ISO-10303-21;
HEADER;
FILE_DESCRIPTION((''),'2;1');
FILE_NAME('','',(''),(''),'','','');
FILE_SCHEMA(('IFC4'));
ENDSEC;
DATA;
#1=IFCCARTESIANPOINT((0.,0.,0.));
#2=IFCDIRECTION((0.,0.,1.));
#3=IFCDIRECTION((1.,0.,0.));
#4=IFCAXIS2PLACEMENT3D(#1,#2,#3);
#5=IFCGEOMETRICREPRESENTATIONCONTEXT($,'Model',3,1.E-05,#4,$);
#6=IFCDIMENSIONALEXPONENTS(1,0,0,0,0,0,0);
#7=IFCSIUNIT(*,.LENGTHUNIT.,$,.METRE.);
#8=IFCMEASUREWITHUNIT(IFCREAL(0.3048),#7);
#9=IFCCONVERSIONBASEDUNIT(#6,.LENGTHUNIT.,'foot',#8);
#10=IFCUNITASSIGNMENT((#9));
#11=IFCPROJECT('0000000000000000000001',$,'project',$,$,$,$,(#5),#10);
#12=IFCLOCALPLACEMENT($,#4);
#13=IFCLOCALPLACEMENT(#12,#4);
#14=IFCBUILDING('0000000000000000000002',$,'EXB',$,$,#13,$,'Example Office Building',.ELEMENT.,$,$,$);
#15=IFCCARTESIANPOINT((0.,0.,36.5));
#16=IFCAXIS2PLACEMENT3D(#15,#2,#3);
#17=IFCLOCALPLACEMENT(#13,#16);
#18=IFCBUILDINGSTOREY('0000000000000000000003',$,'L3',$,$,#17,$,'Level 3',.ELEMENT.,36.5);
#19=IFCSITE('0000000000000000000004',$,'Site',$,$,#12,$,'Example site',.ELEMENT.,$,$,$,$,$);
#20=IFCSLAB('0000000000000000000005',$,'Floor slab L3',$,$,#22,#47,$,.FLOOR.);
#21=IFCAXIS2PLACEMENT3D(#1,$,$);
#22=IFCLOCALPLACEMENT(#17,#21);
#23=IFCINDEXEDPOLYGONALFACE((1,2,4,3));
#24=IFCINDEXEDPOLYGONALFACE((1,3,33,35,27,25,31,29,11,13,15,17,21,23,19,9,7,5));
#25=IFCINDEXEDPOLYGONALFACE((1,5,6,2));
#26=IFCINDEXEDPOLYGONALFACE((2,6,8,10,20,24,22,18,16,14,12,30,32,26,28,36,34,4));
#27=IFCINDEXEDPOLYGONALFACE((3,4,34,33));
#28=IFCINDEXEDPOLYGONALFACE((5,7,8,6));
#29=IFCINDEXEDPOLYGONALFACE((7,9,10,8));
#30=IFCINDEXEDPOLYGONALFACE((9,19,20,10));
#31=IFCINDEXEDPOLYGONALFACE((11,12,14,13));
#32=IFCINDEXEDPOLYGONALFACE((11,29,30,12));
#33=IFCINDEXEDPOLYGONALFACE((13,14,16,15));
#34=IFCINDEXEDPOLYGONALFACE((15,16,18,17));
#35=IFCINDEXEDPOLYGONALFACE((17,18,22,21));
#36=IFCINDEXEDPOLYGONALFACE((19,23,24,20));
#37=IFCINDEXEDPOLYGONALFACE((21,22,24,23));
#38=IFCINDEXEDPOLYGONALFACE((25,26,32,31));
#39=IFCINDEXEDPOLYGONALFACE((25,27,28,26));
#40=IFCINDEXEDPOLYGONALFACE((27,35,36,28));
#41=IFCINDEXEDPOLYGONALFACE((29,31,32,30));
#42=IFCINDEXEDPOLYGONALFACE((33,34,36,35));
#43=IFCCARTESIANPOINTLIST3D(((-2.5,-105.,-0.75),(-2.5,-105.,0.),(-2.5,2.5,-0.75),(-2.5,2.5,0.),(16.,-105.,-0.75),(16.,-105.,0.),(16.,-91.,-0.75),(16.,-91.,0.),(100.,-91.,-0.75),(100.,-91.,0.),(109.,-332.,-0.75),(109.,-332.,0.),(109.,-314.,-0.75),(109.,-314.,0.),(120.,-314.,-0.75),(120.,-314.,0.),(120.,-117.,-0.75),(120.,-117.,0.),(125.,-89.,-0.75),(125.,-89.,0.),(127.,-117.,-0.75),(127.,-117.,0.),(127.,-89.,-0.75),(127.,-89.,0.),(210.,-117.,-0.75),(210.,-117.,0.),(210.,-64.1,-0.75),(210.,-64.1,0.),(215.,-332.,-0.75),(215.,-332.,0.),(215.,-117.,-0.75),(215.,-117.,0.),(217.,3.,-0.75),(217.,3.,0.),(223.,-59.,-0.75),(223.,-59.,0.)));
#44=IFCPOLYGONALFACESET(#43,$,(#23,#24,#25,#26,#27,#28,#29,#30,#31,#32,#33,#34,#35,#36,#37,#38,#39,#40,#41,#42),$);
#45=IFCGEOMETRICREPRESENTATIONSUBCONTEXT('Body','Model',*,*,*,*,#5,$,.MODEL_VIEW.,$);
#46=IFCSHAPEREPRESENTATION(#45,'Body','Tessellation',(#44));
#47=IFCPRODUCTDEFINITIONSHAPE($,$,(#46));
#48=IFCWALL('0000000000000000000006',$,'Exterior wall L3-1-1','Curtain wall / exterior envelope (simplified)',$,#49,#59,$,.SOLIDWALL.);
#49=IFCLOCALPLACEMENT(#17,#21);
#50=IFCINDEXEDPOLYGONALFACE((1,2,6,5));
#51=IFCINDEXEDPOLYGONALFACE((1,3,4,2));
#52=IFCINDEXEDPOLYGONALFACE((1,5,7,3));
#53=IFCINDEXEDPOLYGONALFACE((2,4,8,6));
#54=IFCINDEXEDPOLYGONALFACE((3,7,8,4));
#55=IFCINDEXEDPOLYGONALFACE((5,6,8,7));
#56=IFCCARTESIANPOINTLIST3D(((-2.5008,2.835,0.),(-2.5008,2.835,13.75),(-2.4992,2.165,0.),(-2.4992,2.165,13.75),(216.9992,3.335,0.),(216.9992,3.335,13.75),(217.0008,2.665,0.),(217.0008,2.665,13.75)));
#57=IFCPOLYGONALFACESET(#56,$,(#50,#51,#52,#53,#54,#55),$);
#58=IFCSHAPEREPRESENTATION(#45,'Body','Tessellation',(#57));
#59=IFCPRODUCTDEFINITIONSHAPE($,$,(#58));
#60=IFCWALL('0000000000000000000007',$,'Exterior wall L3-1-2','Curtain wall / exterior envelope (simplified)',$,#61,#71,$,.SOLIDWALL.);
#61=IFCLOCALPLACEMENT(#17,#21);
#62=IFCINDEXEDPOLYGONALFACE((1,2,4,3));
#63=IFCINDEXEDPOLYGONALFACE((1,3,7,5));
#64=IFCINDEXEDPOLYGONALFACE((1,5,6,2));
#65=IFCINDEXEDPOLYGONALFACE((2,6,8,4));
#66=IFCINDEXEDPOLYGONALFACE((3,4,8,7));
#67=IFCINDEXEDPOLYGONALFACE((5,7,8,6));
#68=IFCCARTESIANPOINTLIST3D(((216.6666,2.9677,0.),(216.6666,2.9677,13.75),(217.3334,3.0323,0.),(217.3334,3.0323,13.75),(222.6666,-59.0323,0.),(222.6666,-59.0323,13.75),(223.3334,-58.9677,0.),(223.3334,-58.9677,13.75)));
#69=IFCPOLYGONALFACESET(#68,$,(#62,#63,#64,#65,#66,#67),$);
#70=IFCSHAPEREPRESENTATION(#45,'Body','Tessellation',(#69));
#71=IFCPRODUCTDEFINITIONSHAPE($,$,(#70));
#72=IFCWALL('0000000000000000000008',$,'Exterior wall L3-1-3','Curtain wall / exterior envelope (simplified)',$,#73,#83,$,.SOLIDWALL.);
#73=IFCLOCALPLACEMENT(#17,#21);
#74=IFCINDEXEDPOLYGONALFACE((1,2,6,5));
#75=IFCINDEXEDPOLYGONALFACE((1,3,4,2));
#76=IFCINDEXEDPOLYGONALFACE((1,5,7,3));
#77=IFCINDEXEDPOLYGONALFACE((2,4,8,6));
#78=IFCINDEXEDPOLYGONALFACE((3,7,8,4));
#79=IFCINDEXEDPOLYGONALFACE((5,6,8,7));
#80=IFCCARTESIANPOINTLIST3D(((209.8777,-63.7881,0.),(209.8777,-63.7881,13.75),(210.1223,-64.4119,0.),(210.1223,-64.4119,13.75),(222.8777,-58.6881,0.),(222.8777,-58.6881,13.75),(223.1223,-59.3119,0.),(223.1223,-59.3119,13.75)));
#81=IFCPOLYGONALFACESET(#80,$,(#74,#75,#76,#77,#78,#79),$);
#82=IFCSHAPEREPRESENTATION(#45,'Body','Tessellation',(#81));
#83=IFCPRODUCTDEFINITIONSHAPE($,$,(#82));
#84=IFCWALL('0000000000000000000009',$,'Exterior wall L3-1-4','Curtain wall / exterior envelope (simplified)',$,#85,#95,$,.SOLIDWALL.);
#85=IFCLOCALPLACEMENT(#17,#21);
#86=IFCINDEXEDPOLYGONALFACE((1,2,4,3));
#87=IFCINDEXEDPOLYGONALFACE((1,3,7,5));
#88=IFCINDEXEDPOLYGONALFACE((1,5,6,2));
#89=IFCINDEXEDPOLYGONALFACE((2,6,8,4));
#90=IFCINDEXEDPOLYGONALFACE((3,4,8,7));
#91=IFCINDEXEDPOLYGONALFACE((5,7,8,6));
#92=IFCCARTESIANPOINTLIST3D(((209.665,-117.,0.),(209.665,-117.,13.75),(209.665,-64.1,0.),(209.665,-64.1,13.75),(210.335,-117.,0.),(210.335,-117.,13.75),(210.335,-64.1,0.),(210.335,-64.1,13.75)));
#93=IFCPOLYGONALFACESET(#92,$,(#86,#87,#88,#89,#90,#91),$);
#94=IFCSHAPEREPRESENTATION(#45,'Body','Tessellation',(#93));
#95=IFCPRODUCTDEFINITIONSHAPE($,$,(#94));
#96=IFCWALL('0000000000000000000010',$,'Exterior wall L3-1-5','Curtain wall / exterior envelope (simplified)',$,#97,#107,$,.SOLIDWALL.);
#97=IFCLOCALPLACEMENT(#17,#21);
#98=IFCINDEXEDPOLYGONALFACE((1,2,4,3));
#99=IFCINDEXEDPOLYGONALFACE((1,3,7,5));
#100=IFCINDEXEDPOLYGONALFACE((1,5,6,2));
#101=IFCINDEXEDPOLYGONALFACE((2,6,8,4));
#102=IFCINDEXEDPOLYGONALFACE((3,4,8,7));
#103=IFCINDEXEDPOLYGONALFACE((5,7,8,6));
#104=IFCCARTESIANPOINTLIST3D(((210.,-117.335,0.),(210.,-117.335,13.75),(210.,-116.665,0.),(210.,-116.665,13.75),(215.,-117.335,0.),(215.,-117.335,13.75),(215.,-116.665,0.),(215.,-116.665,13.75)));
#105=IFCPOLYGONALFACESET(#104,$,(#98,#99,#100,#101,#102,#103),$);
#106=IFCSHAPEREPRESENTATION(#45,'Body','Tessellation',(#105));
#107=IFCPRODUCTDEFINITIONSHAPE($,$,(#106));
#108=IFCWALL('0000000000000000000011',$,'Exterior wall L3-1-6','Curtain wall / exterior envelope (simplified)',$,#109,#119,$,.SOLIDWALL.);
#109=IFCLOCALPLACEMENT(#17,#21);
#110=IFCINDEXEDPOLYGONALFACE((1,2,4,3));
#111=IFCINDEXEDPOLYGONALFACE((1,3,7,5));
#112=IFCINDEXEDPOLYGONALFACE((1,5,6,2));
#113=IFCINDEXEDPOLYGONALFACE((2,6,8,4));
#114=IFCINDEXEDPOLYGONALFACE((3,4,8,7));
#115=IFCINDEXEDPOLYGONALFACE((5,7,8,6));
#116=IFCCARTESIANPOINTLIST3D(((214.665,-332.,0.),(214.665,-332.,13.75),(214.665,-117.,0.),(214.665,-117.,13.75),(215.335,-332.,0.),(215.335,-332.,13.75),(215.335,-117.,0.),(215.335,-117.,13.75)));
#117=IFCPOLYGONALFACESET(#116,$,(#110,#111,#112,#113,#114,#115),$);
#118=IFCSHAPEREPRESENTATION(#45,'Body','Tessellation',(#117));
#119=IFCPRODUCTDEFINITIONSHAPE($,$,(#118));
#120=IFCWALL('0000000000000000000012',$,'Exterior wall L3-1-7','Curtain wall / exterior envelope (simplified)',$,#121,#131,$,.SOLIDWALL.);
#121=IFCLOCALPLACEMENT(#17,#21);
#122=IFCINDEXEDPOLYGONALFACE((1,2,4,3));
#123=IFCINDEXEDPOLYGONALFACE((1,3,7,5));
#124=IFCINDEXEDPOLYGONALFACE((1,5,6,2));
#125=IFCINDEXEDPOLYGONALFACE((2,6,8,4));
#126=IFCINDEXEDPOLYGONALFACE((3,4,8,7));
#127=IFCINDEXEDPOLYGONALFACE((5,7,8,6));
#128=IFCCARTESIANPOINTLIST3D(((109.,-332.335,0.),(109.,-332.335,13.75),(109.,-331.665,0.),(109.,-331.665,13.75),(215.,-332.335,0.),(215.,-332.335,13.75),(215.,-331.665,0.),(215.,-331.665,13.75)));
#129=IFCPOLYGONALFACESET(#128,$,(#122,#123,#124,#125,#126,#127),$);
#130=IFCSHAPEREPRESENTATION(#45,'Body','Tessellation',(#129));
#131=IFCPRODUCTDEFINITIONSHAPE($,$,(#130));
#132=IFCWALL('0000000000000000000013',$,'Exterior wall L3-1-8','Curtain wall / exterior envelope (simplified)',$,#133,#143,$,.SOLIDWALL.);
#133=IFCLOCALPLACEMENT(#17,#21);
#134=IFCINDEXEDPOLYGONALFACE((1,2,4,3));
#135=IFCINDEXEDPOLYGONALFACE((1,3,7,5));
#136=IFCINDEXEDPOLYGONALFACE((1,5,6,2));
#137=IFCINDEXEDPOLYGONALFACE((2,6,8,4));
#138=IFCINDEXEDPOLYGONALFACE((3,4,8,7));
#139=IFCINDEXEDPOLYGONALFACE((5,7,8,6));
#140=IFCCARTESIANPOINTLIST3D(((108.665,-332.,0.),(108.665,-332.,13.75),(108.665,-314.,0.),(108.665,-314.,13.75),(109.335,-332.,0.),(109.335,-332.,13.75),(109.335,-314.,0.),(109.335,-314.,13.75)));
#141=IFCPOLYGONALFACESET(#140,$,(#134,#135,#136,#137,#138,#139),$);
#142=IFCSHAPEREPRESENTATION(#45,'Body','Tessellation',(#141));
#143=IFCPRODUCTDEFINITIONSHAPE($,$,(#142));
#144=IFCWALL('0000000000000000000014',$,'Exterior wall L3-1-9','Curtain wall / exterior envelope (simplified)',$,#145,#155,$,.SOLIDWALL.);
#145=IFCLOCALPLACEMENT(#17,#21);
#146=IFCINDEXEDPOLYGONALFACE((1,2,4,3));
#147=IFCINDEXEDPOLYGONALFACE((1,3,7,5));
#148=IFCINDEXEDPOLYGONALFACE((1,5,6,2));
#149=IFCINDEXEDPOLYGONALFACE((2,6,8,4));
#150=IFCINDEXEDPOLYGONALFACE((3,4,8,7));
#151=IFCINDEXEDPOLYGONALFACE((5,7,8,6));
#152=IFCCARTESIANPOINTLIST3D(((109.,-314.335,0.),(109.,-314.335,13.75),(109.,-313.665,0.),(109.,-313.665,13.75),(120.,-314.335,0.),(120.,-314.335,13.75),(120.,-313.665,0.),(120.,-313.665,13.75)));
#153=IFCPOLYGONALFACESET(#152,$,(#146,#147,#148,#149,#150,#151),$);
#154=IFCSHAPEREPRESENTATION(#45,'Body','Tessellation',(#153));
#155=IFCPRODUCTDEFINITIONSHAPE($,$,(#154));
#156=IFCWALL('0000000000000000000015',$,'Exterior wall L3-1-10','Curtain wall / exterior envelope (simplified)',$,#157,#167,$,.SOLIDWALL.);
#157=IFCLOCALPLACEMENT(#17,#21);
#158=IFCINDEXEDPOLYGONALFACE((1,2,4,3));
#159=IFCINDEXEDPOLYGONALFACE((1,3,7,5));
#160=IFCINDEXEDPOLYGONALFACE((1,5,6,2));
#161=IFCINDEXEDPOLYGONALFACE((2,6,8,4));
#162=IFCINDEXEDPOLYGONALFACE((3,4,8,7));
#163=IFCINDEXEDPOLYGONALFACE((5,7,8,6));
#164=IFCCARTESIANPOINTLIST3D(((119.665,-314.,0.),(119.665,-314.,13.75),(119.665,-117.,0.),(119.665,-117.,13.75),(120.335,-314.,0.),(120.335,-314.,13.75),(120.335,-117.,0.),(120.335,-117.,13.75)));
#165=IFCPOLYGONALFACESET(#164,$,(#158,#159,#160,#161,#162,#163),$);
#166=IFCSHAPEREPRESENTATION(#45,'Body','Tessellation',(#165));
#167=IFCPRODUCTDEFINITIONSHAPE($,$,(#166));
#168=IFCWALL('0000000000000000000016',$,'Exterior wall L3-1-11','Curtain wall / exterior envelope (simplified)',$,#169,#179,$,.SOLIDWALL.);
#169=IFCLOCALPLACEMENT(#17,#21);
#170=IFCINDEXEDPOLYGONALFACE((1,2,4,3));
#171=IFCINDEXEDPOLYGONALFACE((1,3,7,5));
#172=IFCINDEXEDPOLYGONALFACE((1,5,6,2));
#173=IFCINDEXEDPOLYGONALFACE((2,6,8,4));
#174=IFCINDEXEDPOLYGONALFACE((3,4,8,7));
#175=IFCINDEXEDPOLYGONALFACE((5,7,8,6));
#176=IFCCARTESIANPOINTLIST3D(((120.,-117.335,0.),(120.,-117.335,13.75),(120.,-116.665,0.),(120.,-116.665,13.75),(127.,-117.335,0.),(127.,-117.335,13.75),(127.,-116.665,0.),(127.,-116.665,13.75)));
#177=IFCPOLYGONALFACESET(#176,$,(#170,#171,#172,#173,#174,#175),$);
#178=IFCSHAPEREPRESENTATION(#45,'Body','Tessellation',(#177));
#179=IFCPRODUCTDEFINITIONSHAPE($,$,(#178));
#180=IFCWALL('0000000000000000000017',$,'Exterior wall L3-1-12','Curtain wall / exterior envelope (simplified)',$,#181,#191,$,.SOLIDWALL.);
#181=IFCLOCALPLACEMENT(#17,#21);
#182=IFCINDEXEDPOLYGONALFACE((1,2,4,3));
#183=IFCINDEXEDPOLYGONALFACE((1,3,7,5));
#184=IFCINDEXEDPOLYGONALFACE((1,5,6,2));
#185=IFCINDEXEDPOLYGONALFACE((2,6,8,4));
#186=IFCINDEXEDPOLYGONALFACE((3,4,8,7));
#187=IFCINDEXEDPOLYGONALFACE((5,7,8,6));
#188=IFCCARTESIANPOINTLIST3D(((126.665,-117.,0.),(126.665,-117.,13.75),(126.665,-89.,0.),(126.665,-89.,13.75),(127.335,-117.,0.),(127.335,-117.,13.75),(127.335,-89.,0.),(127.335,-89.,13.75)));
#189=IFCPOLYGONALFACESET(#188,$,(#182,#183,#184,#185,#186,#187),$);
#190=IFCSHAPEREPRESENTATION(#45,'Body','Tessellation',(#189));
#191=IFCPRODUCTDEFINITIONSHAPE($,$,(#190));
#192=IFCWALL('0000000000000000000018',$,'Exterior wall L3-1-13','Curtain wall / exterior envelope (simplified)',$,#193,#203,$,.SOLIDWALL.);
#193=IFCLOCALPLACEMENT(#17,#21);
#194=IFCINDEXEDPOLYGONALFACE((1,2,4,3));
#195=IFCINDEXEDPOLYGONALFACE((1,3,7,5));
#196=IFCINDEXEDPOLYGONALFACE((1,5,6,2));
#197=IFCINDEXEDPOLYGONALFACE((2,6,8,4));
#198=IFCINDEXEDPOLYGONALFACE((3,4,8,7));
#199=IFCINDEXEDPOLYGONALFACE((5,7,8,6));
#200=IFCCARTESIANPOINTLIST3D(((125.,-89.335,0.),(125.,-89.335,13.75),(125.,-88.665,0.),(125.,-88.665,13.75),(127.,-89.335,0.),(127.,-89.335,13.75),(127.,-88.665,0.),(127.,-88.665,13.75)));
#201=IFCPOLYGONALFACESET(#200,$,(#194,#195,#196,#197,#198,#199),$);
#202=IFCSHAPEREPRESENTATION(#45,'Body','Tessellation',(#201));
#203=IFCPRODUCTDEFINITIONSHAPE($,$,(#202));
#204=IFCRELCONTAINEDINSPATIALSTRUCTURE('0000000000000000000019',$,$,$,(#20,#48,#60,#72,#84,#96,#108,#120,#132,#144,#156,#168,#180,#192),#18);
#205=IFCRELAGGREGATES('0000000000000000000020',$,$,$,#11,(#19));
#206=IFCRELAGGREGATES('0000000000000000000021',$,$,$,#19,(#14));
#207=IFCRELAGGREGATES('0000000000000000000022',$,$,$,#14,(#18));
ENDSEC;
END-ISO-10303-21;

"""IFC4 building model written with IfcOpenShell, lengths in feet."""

from ifc_helpers import new_model, entity, si_unit, converted_unit, frame, frame_2d, origin, origin_with_axes, place, context, subcontext, project, spatial, polyline, rectangle, outline, extrude, element, save


model = new_model("IFC4")

# Units and contexts
model_context = context("Model", 3, precision=1e-05, world=origin_with_axes())
body_context = subcontext(model_context, "Body", "Model", "MODEL_VIEW")
ifc_project = project(units=[converted_unit("LENGTHUNIT", "foot", entity("IfcReal", 0.3048), si_unit("LENGTHUNIT", "METRE"), dimensions=[1, 0, 0, 0, 0, 0, 0])], contexts=[model_context])

# Site, building, storey
site_placement = place(None, origin_with_axes())
site = spatial("IfcSite", under=ifc_project, at=site_placement, Name="Site", LongName="Example site", CompositionType="ELEMENT")
building_placement = place(site_placement, origin_with_axes())
building = spatial("IfcBuilding", under=site, at=building_placement, Name="EXB", LongName="Example Office Building", CompositionType="ELEMENT")
storey_placement = place(building_placement, frame((0.0, 0.0, 36.5), z_axis=(0.0, 0.0, 1.0), x_axis=(1.0, 0.0, 0.0)))
storey = spatial("IfcBuildingStorey", under=building, at=storey_placement, Name="L3", LongName="Level 3", CompositionType="ELEMENT", Elevation=36.5)

# Slab
slab_placement = place(storey_placement, origin_with_axes())
element("IfcSlab", 1, at=slab_placement, inside=storey, Name="Floor slab L3", PredefinedType="FLOOR", context=body_context, shape_type="SweptSolid", body=[
    extrude(outline(polyline([(-2.5, 2.5), (217.0, 3.0), (223.0, -59.0), (210.0, -64.1), (210.0, -117.0), (215.0, -117.0), (215.0, -332.0), (109.0, -332.0), (109.0, -314.0), (120.0, -314.0), (120.0, -117.0), (127.0, -117.0), (127.0, -89.0), (125.0, -89.0), (100.0, -91.0), (16.0, -91.0), (16.0, -105.0), (-2.5, -105.0), (-2.5, 2.5)])), frame((0.0, 0.0, -0.75)), (0.0, 0.0, 1.0), 0.75),
])

# Walls
wall_1_placement = place(storey_placement, frame((-2.5, 2.5, 0.0), z_axis=(0.0, 0.0, 1.0), x_axis=(0.999997, 0.002278, 0.0)))
element("IfcWall", 2, at=wall_1_placement, inside=storey, Name="Exterior wall L3-1-1", Description="Curtain wall / exterior envelope (simplified)", PredefinedType="SOLIDWALL", context=body_context, shape_type="SweptSolid", body=[
    extrude(rectangle(XDim=219.5006, YDim=0.67, at=frame_2d((109.7503, 0.0))), origin(), (0.0, 0.0, 1.0), 13.75),
])
wall_2_placement = place(storey_placement, frame((217.0, 3.0, 0.0), z_axis=(0.0, 0.0, 1.0), x_axis=(0.096324, -0.99535, 0.0)))
element("IfcWall", 3, at=wall_2_placement, inside=storey, Name="Exterior wall L3-1-2", Description="Curtain wall / exterior envelope (simplified)", PredefinedType="SOLIDWALL", context=body_context, shape_type="SweptSolid", body=[
    extrude(rectangle(XDim=62.2896, YDim=0.67, at=frame_2d((31.1448, 0.0))), origin(), (0.0, 0.0, 1.0), 13.75),
])
wall_3_placement = place(storey_placement, frame((223.0, -59.0, 0.0), z_axis=(0.0, 0.0, 1.0), x_axis=(-0.930925, -0.365209, 0.0)))
element("IfcWall", 4, at=wall_3_placement, inside=storey, Name="Exterior wall L3-1-3", Description="Curtain wall / exterior envelope (simplified)", PredefinedType="SOLIDWALL", context=body_context, shape_type="SweptSolid", body=[
    extrude(rectangle(XDim=13.9646, YDim=0.67, at=frame_2d((6.9823, 0.0))), origin(), (0.0, 0.0, 1.0), 13.75),
])
wall_4_placement = place(storey_placement, frame((210.0, -64.1, 0.0), z_axis=(0.0, 0.0, 1.0), x_axis=(0.0, -1.0, 0.0)))
element("IfcWall", 5, at=wall_4_placement, inside=storey, Name="Exterior wall L3-1-4", Description="Curtain wall / exterior envelope (simplified)", PredefinedType="SOLIDWALL", context=body_context, shape_type="SweptSolid", body=[
    extrude(rectangle(XDim=52.9, YDim=0.67, at=frame_2d((26.45, 0.0))), origin(), (0.0, 0.0, 1.0), 13.75),
])
wall_5_placement = place(storey_placement, frame((210.0, -117.0, 0.0), z_axis=(0.0, 0.0, 1.0), x_axis=(1.0, 0.0, 0.0)))
element("IfcWall", 6, at=wall_5_placement, inside=storey, Name="Exterior wall L3-1-5", Description="Curtain wall / exterior envelope (simplified)", PredefinedType="SOLIDWALL", context=body_context, shape_type="SweptSolid", body=[
    extrude(rectangle(XDim=5.0, YDim=0.67, at=frame_2d((2.5, 0.0))), origin(), (0.0, 0.0, 1.0), 13.75),
])
wall_6_placement = place(storey_placement, frame((215.0, -117.0, 0.0), z_axis=(0.0, 0.0, 1.0), x_axis=(0.0, -1.0, 0.0)))
element("IfcWall", 7, at=wall_6_placement, inside=storey, Name="Exterior wall L3-1-6", Description="Curtain wall / exterior envelope (simplified)", PredefinedType="SOLIDWALL", context=body_context, shape_type="SweptSolid", body=[
    extrude(rectangle(XDim=215.0, YDim=0.67, at=frame_2d((107.5, 0.0))), origin(), (0.0, 0.0, 1.0), 13.75),
])
wall_7_placement = place(storey_placement, frame((215.0, -332.0, 0.0), z_axis=(0.0, 0.0, 1.0), x_axis=(-1.0, 0.0, 0.0)))
element("IfcWall", 8, at=wall_7_placement, inside=storey, Name="Exterior wall L3-1-7", Description="Curtain wall / exterior envelope (simplified)", PredefinedType="SOLIDWALL", context=body_context, shape_type="SweptSolid", body=[
    extrude(rectangle(XDim=106.0, YDim=0.67, at=frame_2d((53.0, 0.0))), origin(), (0.0, 0.0, 1.0), 13.75),
])
wall_8_placement = place(storey_placement, frame((109.0, -332.0, 0.0), z_axis=(0.0, 0.0, 1.0), x_axis=(0.0, 1.0, 0.0)))
element("IfcWall", 9, at=wall_8_placement, inside=storey, Name="Exterior wall L3-1-8", Description="Curtain wall / exterior envelope (simplified)", PredefinedType="SOLIDWALL", context=body_context, shape_type="SweptSolid", body=[
    extrude(rectangle(XDim=18.0, YDim=0.67, at=frame_2d((9.0, 0.0))), origin(), (0.0, 0.0, 1.0), 13.75),
])
wall_9_placement = place(storey_placement, frame((109.0, -314.0, 0.0), z_axis=(0.0, 0.0, 1.0), x_axis=(1.0, 0.0, 0.0)))
element("IfcWall", 10, at=wall_9_placement, inside=storey, Name="Exterior wall L3-1-9", Description="Curtain wall / exterior envelope (simplified)", PredefinedType="SOLIDWALL", context=body_context, shape_type="SweptSolid", body=[
    extrude(rectangle(XDim=11.0, YDim=0.67, at=frame_2d((5.5, 0.0))), origin(), (0.0, 0.0, 1.0), 13.75),
])
wall_10_placement = place(storey_placement, frame((120.0, -314.0, 0.0), z_axis=(0.0, 0.0, 1.0), x_axis=(0.0, 1.0, 0.0)))
element("IfcWall", 11, at=wall_10_placement, inside=storey, Name="Exterior wall L3-1-10", Description="Curtain wall / exterior envelope (simplified)", PredefinedType="SOLIDWALL", context=body_context, shape_type="SweptSolid", body=[
    extrude(rectangle(XDim=197.0, YDim=0.67, at=frame_2d((98.5, 0.0))), origin(), (0.0, 0.0, 1.0), 13.75),
])
wall_11_placement = place(storey_placement, frame((120.0, -117.0, 0.0), z_axis=(0.0, 0.0, 1.0), x_axis=(1.0, 0.0, 0.0)))
element("IfcWall", 12, at=wall_11_placement, inside=storey, Name="Exterior wall L3-1-11", Description="Curtain wall / exterior envelope (simplified)", PredefinedType="SOLIDWALL", context=body_context, shape_type="SweptSolid", body=[
    extrude(rectangle(XDim=7.0, YDim=0.67, at=frame_2d((3.5, 0.0))), origin(), (0.0, 0.0, 1.0), 13.75),
])
wall_12_placement = place(storey_placement, frame((127.0, -117.0, 0.0), z_axis=(0.0, 0.0, 1.0), x_axis=(0.0, 1.0, 0.0)))
element("IfcWall", 13, at=wall_12_placement, inside=storey, Name="Exterior wall L3-1-12", Description="Curtain wall / exterior envelope (simplified)", PredefinedType="SOLIDWALL", context=body_context, shape_type="SweptSolid", body=[
    extrude(rectangle(XDim=28.0, YDim=0.67, at=frame_2d((14.0, 0.0))), origin(), (0.0, 0.0, 1.0), 13.75),
])
wall_13_placement = place(storey_placement, frame((127.0, -89.0, 0.0), z_axis=(0.0, 0.0, 1.0), x_axis=(-1.0, 0.0, 0.0)))
element("IfcWall", 14, at=wall_13_placement, inside=storey, Name="Exterior wall L3-1-13", Description="Curtain wall / exterior envelope (simplified)", PredefinedType="SOLIDWALL", context=body_context, shape_type="SweptSolid", body=[
    extrude(rectangle(XDim=2.0, YDim=0.67, at=frame_2d((1.0, 0.0))), origin(), (0.0, 0.0, 1.0), 13.75),
])

save(model, "model.ifc")
